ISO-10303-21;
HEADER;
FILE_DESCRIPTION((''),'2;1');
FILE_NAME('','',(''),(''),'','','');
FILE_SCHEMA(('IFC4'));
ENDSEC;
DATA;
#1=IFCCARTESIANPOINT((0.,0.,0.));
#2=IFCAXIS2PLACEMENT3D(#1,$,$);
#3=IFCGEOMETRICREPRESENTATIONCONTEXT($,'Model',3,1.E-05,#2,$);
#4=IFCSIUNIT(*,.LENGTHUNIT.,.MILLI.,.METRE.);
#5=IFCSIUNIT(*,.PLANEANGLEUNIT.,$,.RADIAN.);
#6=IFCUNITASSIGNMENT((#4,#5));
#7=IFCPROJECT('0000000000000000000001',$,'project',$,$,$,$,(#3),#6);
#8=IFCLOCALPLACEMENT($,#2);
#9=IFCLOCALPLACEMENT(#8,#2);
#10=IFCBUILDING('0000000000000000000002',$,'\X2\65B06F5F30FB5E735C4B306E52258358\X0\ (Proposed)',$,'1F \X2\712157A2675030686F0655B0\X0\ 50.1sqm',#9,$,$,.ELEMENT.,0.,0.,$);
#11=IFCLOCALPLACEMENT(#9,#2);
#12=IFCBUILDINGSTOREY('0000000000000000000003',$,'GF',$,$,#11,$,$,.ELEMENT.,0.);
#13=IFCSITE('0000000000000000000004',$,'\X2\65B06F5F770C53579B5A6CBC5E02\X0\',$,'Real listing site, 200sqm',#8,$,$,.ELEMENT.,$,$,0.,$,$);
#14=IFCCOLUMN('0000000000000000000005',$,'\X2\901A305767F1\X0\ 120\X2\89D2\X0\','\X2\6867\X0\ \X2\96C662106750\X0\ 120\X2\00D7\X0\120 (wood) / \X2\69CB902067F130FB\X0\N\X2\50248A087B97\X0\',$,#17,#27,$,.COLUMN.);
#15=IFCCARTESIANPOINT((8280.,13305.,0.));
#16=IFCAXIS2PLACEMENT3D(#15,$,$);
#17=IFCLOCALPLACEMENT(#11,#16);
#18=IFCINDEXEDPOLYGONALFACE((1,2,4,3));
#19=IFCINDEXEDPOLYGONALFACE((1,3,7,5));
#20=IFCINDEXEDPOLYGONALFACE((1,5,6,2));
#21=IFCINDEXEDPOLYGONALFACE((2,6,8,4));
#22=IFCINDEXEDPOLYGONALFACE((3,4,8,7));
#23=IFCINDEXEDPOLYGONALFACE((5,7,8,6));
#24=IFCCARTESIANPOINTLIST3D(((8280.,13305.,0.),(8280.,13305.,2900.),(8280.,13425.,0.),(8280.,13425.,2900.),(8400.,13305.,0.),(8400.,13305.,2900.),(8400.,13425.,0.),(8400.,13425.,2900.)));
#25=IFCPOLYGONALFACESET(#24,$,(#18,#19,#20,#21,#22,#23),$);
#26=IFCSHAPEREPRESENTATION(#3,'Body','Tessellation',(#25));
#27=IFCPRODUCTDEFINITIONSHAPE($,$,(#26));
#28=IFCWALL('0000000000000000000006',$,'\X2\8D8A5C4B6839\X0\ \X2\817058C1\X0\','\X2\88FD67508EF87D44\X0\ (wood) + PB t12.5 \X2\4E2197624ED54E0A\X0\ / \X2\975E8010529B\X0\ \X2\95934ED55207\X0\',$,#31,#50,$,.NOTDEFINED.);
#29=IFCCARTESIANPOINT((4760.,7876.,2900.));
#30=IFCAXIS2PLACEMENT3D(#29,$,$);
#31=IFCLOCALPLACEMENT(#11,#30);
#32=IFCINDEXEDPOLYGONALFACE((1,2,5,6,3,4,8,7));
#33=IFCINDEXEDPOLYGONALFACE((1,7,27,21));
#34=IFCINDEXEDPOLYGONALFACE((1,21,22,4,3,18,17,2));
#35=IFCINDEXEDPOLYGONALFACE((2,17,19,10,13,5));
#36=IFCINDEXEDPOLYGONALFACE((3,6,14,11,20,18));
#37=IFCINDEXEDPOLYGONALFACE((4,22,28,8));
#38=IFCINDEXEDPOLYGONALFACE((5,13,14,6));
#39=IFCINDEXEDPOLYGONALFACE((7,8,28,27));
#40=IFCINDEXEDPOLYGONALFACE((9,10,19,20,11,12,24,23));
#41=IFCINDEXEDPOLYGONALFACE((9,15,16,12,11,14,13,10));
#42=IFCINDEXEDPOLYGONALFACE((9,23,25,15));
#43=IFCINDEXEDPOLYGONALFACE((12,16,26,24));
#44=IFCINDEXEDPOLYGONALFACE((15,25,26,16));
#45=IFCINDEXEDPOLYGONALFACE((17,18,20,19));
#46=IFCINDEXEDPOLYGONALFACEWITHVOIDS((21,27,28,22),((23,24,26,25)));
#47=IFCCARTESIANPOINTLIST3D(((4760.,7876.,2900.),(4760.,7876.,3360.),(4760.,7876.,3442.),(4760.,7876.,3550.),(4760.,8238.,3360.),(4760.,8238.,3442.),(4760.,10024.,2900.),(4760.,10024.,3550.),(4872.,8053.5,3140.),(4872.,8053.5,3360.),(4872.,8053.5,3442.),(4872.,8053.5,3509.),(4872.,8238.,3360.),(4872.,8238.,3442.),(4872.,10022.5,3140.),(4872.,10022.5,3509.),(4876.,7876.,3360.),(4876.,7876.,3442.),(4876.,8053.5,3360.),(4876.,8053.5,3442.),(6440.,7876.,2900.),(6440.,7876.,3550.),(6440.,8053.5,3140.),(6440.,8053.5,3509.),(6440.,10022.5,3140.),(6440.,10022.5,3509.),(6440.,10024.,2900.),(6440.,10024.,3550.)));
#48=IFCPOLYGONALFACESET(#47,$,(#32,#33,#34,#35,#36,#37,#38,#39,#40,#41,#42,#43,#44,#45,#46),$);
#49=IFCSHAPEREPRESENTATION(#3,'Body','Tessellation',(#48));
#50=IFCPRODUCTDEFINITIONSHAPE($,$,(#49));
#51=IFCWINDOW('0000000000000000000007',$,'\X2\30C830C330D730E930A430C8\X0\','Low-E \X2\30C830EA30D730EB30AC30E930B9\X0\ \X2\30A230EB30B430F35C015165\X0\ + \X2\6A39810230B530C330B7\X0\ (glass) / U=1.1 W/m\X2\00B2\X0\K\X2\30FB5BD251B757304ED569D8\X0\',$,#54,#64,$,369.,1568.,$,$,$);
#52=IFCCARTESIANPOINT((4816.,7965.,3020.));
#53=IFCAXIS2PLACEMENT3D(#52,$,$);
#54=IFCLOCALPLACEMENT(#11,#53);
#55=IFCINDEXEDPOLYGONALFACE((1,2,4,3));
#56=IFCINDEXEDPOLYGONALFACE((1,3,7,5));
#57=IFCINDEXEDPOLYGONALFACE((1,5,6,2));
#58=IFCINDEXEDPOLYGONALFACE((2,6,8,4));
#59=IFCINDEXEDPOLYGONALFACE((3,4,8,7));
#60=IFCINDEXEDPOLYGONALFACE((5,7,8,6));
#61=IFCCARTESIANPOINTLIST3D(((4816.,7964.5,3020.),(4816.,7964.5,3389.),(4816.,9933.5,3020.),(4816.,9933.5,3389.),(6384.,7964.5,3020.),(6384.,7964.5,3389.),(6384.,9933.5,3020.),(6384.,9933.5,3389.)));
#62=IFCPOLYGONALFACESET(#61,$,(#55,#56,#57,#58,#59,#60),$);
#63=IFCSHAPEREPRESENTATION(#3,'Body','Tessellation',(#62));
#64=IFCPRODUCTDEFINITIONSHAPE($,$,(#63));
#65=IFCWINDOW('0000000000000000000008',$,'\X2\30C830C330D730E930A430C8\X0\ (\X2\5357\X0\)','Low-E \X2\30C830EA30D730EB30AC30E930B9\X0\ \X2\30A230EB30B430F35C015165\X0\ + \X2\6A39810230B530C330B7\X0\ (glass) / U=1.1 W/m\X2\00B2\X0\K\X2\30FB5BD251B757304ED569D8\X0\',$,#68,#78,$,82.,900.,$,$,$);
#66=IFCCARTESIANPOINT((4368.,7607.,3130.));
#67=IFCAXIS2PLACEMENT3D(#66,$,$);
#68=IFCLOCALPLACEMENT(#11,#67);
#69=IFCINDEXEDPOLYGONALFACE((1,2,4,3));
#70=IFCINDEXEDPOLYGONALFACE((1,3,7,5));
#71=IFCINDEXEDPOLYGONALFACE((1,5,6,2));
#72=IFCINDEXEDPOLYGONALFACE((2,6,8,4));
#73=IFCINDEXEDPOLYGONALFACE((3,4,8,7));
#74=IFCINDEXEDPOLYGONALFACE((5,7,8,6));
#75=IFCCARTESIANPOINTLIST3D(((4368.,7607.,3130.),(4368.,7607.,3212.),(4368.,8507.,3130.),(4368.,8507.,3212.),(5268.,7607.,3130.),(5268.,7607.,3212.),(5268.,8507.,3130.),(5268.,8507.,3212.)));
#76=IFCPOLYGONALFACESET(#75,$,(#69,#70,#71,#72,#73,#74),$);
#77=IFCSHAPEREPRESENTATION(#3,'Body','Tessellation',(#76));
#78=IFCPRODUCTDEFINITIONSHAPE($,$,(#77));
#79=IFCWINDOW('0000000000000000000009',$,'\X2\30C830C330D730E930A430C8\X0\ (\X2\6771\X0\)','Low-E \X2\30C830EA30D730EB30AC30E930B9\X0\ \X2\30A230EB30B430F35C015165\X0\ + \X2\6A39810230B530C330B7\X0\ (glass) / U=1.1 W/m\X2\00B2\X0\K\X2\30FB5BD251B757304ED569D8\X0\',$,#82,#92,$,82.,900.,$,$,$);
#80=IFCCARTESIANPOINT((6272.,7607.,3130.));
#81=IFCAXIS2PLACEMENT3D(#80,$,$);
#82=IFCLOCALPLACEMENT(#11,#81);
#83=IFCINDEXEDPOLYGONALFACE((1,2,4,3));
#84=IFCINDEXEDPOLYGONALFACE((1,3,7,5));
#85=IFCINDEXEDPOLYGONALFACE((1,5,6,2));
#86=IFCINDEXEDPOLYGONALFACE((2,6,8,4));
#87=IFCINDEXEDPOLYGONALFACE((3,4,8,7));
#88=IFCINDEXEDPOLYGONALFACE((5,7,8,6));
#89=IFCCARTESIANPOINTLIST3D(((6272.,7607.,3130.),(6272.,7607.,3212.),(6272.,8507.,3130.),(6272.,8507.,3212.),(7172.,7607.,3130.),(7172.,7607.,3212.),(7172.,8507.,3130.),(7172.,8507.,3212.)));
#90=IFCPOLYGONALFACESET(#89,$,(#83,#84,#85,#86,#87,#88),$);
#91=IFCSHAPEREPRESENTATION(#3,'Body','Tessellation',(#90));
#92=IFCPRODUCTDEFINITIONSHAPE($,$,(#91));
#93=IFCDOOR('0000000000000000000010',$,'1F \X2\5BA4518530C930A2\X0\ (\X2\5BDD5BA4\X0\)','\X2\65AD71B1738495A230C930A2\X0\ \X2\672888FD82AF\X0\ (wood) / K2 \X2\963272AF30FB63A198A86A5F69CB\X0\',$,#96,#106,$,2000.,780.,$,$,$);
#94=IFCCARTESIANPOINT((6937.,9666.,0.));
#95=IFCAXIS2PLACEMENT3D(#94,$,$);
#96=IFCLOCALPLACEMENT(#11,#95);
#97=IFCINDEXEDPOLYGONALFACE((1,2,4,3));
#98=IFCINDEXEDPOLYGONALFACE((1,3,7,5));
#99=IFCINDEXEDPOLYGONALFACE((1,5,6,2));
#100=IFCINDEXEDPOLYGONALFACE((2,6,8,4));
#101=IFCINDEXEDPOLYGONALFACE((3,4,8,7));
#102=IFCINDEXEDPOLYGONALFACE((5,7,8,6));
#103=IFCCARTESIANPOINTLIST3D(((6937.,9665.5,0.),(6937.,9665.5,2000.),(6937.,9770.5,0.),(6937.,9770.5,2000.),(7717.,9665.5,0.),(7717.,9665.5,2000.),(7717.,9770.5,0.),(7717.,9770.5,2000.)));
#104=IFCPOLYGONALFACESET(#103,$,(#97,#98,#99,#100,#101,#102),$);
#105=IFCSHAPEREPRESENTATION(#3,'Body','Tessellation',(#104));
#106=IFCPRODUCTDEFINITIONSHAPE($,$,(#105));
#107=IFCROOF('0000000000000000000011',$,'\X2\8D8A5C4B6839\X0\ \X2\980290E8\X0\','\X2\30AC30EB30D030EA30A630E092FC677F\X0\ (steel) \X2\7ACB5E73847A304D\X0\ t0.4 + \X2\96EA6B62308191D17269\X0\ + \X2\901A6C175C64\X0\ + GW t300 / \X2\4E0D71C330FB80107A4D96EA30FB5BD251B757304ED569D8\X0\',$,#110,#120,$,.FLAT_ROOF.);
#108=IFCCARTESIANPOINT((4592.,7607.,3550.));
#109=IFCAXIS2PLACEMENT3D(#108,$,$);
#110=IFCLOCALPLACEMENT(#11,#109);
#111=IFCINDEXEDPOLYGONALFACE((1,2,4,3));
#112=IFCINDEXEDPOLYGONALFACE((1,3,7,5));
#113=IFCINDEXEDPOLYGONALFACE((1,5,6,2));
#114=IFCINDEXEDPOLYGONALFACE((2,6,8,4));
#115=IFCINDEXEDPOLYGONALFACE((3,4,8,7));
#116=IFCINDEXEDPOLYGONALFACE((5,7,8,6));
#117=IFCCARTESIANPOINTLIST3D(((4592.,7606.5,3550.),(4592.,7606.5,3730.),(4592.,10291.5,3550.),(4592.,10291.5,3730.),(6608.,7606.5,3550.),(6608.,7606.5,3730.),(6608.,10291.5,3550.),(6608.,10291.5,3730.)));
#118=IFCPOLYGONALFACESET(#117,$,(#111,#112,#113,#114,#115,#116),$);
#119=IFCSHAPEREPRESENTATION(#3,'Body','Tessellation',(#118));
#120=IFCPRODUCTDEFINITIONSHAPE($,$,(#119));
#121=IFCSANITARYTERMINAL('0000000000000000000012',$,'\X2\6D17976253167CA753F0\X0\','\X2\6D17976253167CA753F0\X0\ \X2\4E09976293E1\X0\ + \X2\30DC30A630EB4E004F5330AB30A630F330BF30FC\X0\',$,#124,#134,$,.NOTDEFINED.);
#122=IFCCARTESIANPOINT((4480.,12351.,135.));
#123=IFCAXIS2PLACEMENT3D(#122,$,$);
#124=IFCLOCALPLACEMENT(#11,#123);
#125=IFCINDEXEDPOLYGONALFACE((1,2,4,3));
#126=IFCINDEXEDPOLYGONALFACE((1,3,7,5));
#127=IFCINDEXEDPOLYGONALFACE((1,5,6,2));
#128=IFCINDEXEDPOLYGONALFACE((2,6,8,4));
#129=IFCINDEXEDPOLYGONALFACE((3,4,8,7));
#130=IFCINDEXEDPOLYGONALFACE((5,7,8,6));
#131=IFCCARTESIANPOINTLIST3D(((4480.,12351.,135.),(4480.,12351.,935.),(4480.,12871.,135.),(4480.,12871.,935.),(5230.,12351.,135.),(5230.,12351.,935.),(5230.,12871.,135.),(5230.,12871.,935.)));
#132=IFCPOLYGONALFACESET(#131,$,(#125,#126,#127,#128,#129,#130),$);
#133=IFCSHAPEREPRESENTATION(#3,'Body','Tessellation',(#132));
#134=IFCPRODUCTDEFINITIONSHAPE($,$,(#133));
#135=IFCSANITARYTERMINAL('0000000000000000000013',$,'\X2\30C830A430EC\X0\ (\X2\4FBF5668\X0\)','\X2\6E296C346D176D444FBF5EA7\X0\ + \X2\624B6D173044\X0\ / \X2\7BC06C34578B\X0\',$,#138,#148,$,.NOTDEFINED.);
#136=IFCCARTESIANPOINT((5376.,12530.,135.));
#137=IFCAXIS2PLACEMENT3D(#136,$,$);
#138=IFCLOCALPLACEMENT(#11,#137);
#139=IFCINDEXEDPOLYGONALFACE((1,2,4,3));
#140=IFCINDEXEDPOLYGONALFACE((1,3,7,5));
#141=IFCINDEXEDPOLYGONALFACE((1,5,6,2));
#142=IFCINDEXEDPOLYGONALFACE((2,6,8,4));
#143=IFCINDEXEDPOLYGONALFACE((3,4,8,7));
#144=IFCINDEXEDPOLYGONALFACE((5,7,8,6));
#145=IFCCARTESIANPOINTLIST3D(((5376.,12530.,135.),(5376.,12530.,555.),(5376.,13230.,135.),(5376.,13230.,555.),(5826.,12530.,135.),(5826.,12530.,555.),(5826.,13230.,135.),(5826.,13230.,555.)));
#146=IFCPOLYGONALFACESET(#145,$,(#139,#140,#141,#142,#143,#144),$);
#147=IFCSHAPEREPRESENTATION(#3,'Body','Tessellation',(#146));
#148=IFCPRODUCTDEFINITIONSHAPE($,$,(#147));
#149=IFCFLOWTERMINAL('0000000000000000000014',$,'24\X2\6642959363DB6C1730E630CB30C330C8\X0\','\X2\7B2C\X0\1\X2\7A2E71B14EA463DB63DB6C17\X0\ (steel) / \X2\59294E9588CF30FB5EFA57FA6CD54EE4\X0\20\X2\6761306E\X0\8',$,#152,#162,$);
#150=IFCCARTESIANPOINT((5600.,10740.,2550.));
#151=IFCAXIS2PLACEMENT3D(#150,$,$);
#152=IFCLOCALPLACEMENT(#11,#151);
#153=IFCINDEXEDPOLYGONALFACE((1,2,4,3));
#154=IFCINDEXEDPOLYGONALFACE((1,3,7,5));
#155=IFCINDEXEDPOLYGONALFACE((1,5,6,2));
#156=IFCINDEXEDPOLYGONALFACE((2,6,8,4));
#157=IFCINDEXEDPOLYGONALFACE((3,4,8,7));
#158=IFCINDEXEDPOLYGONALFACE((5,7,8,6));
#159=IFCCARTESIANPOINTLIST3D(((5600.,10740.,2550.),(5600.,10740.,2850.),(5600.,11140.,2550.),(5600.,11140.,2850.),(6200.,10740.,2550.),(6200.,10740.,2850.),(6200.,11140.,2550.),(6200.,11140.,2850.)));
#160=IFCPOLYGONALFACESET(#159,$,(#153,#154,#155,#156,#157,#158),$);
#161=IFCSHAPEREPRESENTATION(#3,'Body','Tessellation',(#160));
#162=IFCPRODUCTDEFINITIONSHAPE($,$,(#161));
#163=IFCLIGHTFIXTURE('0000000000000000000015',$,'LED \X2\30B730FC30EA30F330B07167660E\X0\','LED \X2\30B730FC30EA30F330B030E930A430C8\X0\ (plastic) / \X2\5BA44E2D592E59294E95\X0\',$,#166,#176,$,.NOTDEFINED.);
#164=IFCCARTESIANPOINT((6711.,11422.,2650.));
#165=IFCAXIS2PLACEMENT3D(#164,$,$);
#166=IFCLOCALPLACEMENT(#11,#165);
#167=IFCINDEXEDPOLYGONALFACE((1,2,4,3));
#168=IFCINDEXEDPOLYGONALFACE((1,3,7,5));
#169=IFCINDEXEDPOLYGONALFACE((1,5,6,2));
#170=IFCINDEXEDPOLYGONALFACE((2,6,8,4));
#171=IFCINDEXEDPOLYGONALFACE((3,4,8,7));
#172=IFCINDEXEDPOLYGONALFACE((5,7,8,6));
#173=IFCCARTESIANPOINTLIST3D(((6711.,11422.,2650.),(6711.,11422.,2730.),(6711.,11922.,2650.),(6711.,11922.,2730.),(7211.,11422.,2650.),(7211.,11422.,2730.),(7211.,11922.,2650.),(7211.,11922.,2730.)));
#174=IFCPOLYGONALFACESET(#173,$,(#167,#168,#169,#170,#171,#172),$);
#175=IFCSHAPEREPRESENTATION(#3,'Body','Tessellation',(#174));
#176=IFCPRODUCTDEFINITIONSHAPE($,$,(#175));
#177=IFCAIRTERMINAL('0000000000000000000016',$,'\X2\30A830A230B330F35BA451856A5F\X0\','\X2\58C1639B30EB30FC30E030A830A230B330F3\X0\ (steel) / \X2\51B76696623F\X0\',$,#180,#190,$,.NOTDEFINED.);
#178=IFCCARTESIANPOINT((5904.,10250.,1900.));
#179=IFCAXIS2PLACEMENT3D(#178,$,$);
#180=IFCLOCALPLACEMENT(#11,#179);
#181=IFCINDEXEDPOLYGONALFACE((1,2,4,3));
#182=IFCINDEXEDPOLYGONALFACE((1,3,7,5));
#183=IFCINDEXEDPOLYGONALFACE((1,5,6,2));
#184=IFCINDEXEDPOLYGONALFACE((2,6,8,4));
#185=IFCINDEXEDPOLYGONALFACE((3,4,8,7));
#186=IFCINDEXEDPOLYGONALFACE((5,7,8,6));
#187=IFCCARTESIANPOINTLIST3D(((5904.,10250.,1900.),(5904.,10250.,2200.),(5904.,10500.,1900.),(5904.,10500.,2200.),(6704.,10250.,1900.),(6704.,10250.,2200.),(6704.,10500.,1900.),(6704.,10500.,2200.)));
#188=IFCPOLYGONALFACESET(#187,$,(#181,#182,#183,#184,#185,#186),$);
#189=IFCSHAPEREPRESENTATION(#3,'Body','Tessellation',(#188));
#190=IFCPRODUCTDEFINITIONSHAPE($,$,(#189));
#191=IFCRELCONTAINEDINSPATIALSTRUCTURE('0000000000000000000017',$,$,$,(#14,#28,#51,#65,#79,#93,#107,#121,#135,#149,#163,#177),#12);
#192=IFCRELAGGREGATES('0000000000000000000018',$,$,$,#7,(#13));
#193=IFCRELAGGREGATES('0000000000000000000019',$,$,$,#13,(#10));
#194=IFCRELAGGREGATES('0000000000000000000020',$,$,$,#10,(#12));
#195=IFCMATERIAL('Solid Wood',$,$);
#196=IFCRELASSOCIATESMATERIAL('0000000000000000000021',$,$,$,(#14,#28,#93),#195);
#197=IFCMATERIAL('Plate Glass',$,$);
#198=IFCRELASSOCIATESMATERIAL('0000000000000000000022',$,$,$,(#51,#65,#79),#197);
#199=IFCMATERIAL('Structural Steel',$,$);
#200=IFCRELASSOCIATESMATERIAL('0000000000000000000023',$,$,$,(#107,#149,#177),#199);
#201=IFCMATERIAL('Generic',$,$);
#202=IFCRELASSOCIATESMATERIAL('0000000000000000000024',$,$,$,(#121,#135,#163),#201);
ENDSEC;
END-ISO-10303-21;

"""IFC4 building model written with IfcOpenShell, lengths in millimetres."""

from ifc_helpers import new_model, si_unit, frame, frame_2d, origin, place, context, project, spatial, rectangle, extrude, material, element, fill, save


model = new_model("IFC4")

# Units and contexts
model_context = context("Model", 3, precision=1e-05, world=origin())
ifc_project = project(units=[si_unit("LENGTHUNIT", "METRE", prefix="MILLI"), si_unit("PLANEANGLEUNIT", "RADIAN")], contexts=[model_context])

# Site, building, storey
site_placement = place(None, origin())
site = spatial("IfcSite", under=ifc_project, at=site_placement, Name="新潟県南魚沼市", ObjectType="Real listing site, 200sqm", CompositionType="ELEMENT", RefElevation=0.0)
building_placement = place(site_placement, origin())
building = spatial("IfcBuilding", under=site, at=building_placement, Name="新潟・平屋の別荘 (Proposed)", ObjectType="1F 無垢材と漆喰 50.1sqm", CompositionType="ELEMENT", ElevationOfRefHeight=0.0, ElevationOfTerrain=0.0)
storey_placement = place(building_placement, origin())
storey = spatial("IfcBuildingStorey", under=building, at=storey_placement, Name="GF", CompositionType="ELEMENT", Elevation=0.0)

# Column
ifc_material_1 = material(Name="Solid Wood")
column_1_placement = place(storey_placement, frame((8280.0, 13305.0, 0.0)))
element("IfcColumn", 1, at=column_1_placement, inside=storey, material=ifc_material_1, Name="通し柱 120角", Description="桧 集成材 120×120 (wood) / 構造柱・N値計算", PredefinedType="COLUMN", context=model_context, shape_type="SweptSolid", body=[
    extrude(rectangle(XDim=120.0, YDim=120.0, at=frame_2d((60.0, 60.0))), frame((8280.0, 13305.0, 0.0)), (0.0, 0.0, 1.0), 2900.0),
])

# Wall, openings, windows
wall_1_placement = place(storey_placement, frame((4760.0, 7876.0, 2900.0)))
wall_1 = element("IfcWall", 2, at=wall_1_placement, inside=storey, material=ifc_material_1, Name="越屋根 腰壁", Description="製材軸組 (wood) + PB t12.5 両面仕上 / 非耐力 間仕切", PredefinedType="NOTDEFINED", context=model_context, shape_type="SweptSolid", body=[
    extrude(rectangle(XDim=1680.0, YDim=2148.0, at=frame_2d((840.0, 1074.0))), frame((4760.0, 7876.0, 2900.0)), (0.0, 0.0, 1.0), 650.0),
])
opening_1_placement = place(storey_placement, frame((4816.0, 7965.0, 3020.0)))
opening_1 = element("IfcOpeningElement", 3, at=opening_1_placement, cuts=wall_1, PredefinedType="NOTDEFINED", context=model_context, shape_type="SweptSolid", body=[
    extrude(rectangle(XDim=1568.0, YDim=1969.0, at=frame_2d((784.0, 984.0))), frame((4816.0, 7965.0, 3020.0)), (0.0, 0.0, 1.0), 369.0),
])
opening_2_placement = place(storey_placement, frame((4368.0, 7607.0, 3130.0)))
opening_2 = element("IfcOpeningElement", 4, at=opening_2_placement, cuts=wall_1, PredefinedType="NOTDEFINED", context=model_context, shape_type="SweptSolid", body=[
    extrude(rectangle(XDim=900.0, YDim=900.0, at=frame_2d((450.0, 450.0))), frame((4368.0, 7607.0, 3130.0)), (0.0, 0.0, 1.0), 82.0),
])
opening_3_placement = place(storey_placement, frame((6272.0, 7607.0, 3130.0)))
opening_3 = element("IfcOpeningElement", 5, at=opening_3_placement, cuts=wall_1, PredefinedType="NOTDEFINED", context=model_context, shape_type="SweptSolid", body=[
    extrude(rectangle(XDim=900.0, YDim=900.0, at=frame_2d((450.0, 450.0))), frame((6272.0, 7607.0, 3130.0)), (0.0, 0.0, 1.0), 82.0),
])
ifc_material_2 = material(Name="Plate Glass")
window_1_placement = place(storey_placement, frame((4816.0, 7965.0, 3020.0)))
window_1 = element("IfcWindow", 6, at=window_1_placement, inside=storey, material=ifc_material_2, Name="トップライト", Description="Low-E トリプルガラス アルゴン封入 + 樹脂サッシ (glass) / U=1.1 W/m²K・寒冷地仕様", OverallHeight=369.0, OverallWidth=1568.0, context=model_context, shape_type="SweptSolid", body=[
    extrude(rectangle(XDim=1568.0, YDim=1969.0, at=frame_2d((784.0, 984.0))), frame((4816.0, 7965.0, 3020.0)), (0.0, 0.0, 1.0), 369.0),
])
fill(opening_1, window_1)
window_2_placement = place(storey_placement, frame((4368.0, 7607.0, 3130.0)))
window_2 = element("IfcWindow", 7, at=window_2_placement, inside=storey, material=ifc_material_2, Name="トップライト (南)", Description="Low-E トリプルガラス アルゴン封入 + 樹脂サッシ (glass) / U=1.1 W/m²K・寒冷地仕様", OverallHeight=82.0, OverallWidth=900.0, context=model_context, shape_type="SweptSolid", body=[
    extrude(rectangle(XDim=900.0, YDim=900.0, at=frame_2d((450.0, 450.0))), frame((4368.0, 7607.0, 3130.0)), (0.0, 0.0, 1.0), 82.0),
])
fill(opening_2, window_2)
window_3_placement = place(storey_placement, frame((6272.0, 7607.0, 3130.0)))
window_3 = element("IfcWindow", 8, at=window_3_placement, inside=storey, material=ifc_material_2, Name="トップライト (東)", Description="Low-E トリプルガラス アルゴン封入 + 樹脂サッシ (glass) / U=1.1 W/m²K・寒冷地仕様", OverallHeight=82.0, OverallWidth=900.0, context=model_context, shape_type="SweptSolid", body=[
    extrude(rectangle(XDim=900.0, YDim=900.0, at=frame_2d((450.0, 450.0))), frame((6272.0, 7607.0, 3130.0)), (0.0, 0.0, 1.0), 82.0),
])
fill(opening_3, window_3)

# Door
door_placement = place(storey_placement, frame((6937.0, 9666.0, 0.0)))
element("IfcDoor", 9, at=door_placement, inside=storey, material=ifc_material_1, Name="1F 室内ドア (寝室)", Description="断熱玄関ドア 木製芯 (wood) / K2 防犯・採風機構", OverallHeight=2000.0, OverallWidth=780.0, context=model_context, shape_type="SweptSolid", body=[
    extrude(rectangle(XDim=780.0, YDim=105.0, at=frame_2d((390.0, 52.0))), frame((6937.0, 9666.0, 0.0)), (0.0, 0.0, 1.0), 2000.0),
])

# Roof
ifc_material_3 = material(Name="Structural Steel")
roof_placement = place(storey_placement, frame((4592.0, 7607.0, 3550.0)))
element("IfcRoof", 10, at=roof_placement, inside=storey, material=ifc_material_3, Name="越屋根 頂部", Description="ガルバリウム鋼板 (steel) 立平葺き t0.4 + 雪止め金物 + 通気層 + GW t300 / 不燃・耐積雪・寒冷地仕様", PredefinedType="FLAT_ROOF", context=model_context, shape_type="SweptSolid", body=[
    extrude(rectangle(XDim=2016.0, YDim=2685.0, at=frame_2d((1008.0, 1342.0))), frame((4592.0, 7607.0, 3550.0)), (0.0, 0.0, 1.0), 180.0),
])

# Sanitary terminals
ifc_material_4 = material(Name="Generic")
sanitary_terminal_1_placement = place(storey_placement, frame((4480.0, 12351.0, 135.0)))
element("IfcSanitaryTerminal", 11, at=sanitary_terminal_1_placement, inside=storey, material=ifc_material_4, Name="洗面化粧台", Description="洗面化粧台 三面鏡 + ボウル一体カウンター", PredefinedType="NOTDEFINED", context=model_context, shape_type="SweptSolid", body=[
    extrude(rectangle(XDim=750.0, YDim=520.0, at=frame_2d((375.0, 260.0))), frame((4480.0, 12351.0, 135.0)), (0.0, 0.0, 1.0), 800.0),
])
sanitary_terminal_2_placement = place(storey_placement, frame((5376.0, 12530.0, 135.0)))
element("IfcSanitaryTerminal", 12, at=sanitary_terminal_2_placement, inside=storey, material=ifc_material_4, Name="トイレ (便器)", Description="温水洗浄便座 + 手洗い / 節水型", PredefinedType="NOTDEFINED", context=model_context, shape_type="SweptSolid", body=[
    extrude(rectangle(XDim=450.0, YDim=700.0, at=frame_2d((225.0, 350.0))), frame((5376.0, 12530.0, 135.0)), (0.0, 0.0, 1.0), 420.0),
])

# Flow terminal
flow_terminal_placement = place(storey_placement, frame((5600.0, 10740.0, 2550.0)))
element("IfcFlowTerminal", 13, at=flow_terminal_placement, inside=storey, material=ifc_material_3, Name="24時間換気ユニット", Description="第1種熱交換換気 (steel) / 天井裏・建基法令20条の8", context=model_context, shape_type="SweptSolid", body=[
    extrude(rectangle(XDim=600.0, YDim=400.0, at=frame_2d((300.0, 200.0))), frame((5600.0, 10740.0, 2550.0)), (0.0, 0.0, 1.0), 300.0),
])

# Light fixture
light_fixture_placement = place(storey_placement, frame((6711.0, 11422.0, 2650.0)))
element("IfcLightFixture", 14, at=light_fixture_placement, inside=storey, material=ifc_material_4, Name="LED シーリング照明", Description="LED シーリングライト (plastic) / 室中央天井", PredefinedType="NOTDEFINED", context=model_context, shape_type="SweptSolid", body=[
    extrude(rectangle(XDim=500.0, YDim=500.0, at=frame_2d((250.0, 250.0))), frame((6711.0, 11422.0, 2650.0)), (0.0, 0.0, 1.0), 80.0),
])

# Air terminal
air_terminal_placement = place(storey_placement, frame((5904.0, 10250.0, 1900.0)))
element("IfcAirTerminal", 15, at=air_terminal_placement, inside=storey, material=ifc_material_3, Name="エアコン室内機", Description="壁掛ルームエアコン (steel) / 冷暖房", PredefinedType="NOTDEFINED", context=model_context, shape_type="SweptSolid", body=[
    extrude(rectangle(XDim=800.0, YDim=250.0, at=frame_2d((400.0, 125.0))), frame((5904.0, 10250.0, 1900.0)), (0.0, 0.0, 1.0), 300.0),
])

save(model, "model.ifc")
